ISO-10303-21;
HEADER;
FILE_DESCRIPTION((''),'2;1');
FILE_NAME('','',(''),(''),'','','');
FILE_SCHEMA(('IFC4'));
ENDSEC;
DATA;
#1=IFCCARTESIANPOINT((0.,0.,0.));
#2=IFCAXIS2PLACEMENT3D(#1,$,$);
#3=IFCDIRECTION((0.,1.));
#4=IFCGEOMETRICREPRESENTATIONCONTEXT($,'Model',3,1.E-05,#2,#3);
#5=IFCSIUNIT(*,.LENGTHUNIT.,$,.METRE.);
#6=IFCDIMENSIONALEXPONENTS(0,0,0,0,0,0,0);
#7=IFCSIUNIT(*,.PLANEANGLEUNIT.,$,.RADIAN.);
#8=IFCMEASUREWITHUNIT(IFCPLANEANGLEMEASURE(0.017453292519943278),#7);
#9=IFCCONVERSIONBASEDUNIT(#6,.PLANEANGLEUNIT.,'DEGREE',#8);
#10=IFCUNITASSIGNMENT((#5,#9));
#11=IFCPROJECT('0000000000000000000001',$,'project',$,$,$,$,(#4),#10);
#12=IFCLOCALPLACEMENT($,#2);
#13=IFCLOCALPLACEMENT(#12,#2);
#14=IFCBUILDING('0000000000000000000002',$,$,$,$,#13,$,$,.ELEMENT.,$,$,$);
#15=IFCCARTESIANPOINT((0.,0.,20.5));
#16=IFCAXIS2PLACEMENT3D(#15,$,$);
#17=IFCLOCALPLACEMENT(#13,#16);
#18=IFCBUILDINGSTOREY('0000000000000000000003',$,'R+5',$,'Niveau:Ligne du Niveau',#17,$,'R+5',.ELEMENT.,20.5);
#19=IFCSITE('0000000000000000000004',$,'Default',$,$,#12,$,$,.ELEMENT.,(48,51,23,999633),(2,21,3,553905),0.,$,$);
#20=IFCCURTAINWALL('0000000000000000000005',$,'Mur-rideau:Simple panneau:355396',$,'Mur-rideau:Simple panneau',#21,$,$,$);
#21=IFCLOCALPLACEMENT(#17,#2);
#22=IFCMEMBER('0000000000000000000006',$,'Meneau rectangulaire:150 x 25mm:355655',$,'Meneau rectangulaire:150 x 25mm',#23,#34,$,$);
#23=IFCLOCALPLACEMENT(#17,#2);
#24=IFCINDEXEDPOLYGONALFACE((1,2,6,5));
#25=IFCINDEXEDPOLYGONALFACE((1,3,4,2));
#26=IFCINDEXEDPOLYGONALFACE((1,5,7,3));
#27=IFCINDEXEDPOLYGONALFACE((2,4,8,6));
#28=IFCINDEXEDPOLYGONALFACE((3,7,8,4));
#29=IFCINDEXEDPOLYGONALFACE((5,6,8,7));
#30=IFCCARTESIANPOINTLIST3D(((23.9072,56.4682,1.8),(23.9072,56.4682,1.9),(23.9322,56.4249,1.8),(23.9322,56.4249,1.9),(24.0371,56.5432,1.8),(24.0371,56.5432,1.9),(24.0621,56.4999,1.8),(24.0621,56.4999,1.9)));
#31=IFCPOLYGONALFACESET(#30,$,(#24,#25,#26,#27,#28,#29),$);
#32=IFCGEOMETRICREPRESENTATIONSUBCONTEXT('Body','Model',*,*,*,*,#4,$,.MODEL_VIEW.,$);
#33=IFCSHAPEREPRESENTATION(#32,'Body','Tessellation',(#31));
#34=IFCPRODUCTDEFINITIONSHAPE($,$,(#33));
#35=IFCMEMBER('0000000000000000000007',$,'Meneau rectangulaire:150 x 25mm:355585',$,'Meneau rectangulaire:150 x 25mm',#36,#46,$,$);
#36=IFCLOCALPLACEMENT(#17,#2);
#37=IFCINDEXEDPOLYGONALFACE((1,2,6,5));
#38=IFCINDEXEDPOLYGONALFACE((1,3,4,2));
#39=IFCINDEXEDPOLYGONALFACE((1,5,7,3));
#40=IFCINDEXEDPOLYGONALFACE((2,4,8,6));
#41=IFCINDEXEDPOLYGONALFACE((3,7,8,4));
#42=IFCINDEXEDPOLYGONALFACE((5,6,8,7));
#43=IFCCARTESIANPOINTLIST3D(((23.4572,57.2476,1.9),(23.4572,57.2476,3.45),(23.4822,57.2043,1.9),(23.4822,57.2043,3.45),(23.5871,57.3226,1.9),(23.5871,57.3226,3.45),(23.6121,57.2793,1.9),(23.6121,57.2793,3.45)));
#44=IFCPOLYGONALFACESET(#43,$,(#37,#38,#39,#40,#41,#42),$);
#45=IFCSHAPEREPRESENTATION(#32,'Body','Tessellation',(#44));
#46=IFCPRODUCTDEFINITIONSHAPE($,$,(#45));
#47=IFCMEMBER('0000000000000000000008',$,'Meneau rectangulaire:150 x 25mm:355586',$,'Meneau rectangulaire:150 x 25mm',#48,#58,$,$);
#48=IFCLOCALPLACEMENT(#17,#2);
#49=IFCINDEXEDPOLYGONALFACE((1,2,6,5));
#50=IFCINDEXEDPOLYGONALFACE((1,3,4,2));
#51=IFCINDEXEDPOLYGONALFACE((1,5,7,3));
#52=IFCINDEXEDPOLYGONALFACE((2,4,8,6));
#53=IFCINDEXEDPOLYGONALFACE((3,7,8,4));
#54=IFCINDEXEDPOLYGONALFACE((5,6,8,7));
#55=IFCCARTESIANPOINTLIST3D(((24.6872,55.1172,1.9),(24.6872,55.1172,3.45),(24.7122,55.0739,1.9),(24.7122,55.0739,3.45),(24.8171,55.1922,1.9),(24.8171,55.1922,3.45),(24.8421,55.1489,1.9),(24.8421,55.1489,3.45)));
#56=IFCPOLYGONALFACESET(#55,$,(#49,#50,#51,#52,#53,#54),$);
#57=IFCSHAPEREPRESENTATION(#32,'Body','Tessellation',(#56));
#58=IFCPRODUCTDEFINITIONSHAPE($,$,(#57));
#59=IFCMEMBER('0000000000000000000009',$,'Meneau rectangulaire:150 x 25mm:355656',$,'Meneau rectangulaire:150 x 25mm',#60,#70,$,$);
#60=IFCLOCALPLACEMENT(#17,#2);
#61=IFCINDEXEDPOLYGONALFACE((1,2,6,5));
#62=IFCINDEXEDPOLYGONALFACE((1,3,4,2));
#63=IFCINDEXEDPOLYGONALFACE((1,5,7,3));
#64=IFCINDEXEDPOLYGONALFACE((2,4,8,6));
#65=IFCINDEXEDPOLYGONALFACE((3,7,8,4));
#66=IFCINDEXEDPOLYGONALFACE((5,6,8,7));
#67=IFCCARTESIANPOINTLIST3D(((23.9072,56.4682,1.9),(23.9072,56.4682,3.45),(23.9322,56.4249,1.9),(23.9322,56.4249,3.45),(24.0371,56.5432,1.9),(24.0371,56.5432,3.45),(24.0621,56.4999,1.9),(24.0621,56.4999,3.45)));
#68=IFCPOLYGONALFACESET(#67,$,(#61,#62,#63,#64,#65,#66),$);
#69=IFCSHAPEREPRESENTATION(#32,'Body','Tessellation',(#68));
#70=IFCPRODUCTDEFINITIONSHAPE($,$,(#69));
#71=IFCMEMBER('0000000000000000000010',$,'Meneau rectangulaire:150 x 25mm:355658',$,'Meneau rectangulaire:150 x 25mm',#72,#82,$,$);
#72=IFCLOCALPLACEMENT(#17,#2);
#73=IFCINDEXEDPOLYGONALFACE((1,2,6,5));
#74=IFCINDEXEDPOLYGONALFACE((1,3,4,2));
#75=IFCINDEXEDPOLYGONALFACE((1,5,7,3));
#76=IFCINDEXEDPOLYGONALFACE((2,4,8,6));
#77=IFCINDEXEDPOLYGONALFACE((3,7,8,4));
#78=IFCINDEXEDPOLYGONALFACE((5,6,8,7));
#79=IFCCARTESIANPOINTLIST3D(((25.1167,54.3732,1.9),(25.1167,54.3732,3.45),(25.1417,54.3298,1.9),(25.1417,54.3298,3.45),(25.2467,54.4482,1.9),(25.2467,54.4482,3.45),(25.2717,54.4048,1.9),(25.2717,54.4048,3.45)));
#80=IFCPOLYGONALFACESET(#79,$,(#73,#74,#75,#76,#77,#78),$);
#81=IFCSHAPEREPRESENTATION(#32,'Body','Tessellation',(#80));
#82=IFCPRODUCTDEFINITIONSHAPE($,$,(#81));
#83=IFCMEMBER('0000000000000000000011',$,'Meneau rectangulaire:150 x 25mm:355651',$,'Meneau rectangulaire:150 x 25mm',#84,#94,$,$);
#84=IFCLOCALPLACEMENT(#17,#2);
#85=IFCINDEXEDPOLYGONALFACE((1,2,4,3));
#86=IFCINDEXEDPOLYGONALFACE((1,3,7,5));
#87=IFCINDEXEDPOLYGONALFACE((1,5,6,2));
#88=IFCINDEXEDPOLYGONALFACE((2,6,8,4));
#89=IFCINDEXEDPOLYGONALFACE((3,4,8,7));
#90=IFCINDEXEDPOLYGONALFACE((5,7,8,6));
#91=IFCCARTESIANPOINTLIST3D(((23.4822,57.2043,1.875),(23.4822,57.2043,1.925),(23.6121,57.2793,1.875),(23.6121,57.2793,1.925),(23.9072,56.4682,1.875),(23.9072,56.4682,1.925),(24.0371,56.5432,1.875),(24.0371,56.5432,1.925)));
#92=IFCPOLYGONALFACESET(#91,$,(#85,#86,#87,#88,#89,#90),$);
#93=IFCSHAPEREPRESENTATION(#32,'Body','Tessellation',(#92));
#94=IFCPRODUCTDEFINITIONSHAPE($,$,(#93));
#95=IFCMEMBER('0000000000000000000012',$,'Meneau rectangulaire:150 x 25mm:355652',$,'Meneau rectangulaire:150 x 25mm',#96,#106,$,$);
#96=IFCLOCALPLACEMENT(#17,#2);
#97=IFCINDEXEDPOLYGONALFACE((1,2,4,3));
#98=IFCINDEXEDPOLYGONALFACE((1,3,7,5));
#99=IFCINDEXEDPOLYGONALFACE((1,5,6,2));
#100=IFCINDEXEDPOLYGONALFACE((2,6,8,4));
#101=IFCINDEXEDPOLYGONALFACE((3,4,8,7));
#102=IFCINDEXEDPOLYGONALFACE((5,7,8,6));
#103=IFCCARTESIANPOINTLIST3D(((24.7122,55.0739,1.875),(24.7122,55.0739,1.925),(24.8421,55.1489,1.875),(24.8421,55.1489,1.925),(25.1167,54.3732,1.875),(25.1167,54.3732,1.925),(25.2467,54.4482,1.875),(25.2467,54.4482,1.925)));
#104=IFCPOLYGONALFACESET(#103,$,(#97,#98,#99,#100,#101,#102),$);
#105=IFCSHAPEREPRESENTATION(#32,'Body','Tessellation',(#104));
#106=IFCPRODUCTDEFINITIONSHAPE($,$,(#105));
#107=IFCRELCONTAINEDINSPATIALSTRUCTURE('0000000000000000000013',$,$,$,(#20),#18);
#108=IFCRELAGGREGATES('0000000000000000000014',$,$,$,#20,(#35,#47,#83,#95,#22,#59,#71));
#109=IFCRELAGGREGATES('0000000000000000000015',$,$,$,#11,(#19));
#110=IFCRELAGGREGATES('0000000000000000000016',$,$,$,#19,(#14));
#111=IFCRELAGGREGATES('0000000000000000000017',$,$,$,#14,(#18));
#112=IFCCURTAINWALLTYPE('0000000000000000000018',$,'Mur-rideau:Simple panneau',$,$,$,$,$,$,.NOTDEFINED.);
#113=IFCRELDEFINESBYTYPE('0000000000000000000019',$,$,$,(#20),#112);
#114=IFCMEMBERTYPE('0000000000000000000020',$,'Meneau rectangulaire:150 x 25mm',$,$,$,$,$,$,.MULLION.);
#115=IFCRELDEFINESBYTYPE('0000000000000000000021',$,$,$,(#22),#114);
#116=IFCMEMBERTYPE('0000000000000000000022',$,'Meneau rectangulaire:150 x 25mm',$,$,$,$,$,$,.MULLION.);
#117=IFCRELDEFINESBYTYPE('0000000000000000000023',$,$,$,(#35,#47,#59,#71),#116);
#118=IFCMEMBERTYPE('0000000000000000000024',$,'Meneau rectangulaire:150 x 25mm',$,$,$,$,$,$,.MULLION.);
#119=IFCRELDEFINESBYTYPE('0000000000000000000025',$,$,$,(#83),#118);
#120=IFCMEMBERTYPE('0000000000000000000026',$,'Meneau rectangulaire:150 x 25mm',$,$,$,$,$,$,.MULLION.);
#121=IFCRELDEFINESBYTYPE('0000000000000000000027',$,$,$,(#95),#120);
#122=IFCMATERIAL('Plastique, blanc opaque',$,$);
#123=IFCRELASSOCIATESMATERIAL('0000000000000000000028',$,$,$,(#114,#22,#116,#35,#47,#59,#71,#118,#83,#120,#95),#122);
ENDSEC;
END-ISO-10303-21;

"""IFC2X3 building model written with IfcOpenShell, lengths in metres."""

from ifc_helpers import new_model, entity, si_unit, converted_unit, direction, frame, origin, origin_2d_with_axis, place, context, subcontext, project, spatial, rectangle, extrude, source, transform, mapped, material, type_object, type_shapes, element, aggregate, save


model = new_model("IFC2X3")

# Units and contexts
model_context = context("Model", 3, precision=1e-05, world=origin(), true_north=direction((0.0, 1.0)))
body_context = subcontext(model_context, "Body", "Model", "MODEL_VIEW")
ifc_project = project(units=[si_unit("LENGTHUNIT", "METRE"), converted_unit("PLANEANGLEUNIT", "DEGREE", entity("IfcPlaneAngleMeasure", 0.017453292519943278), si_unit("PLANEANGLEUNIT", "RADIAN"), dimensions=[0, 0, 0, 0, 0, 0, 0])], contexts=[model_context])

# Site, building, storey
site_placement = place(None, origin())
site = spatial("IfcSite", under=ifc_project, at=site_placement, Name="Default", CompositionType="ELEMENT", RefLatitude=(48, 51, 23, 999633), RefLongitude=(2, 21, 3, 553905), RefElevation=0.0)
building_placement = place(site_placement, origin())
building = spatial("IfcBuilding", under=site, at=building_placement, CompositionType="ELEMENT")
storey_placement = place(building_placement, frame((0.0, 0.0, 20.5)))
storey = spatial("IfcBuildingStorey", under=building, at=storey_placement, Name="R+5", ObjectType="Niveau:Ligne du Niveau", LongName="R+5", CompositionType="ELEMENT", Elevation=20.5)

# Curtain wall, members
curtain_wall_type = type_object("IfcCurtainWallType", Name="Mur-rideau:Simple panneau", PredefinedType="NOTDEFINED")
curtain_wall_placement = place(storey_placement, frame((0.0, 0.0, -20.5)))
curtain_wall = element("IfcCurtainWall", 1, at=curtain_wall_placement, inside=storey, type_object=curtain_wall_type, Name="Mur-rideau:Simple panneau:355396", ObjectType="Mur-rideau:Simple panneau")
ifc_material_1 = material(Name="Plastique, blanc opaque")
member_type_1 = type_object("IfcMemberType", Name="Meneau rectangulaire:150 x 25mm", PredefinedType="MULLION", material=ifc_material_1)
shared_shape_1 = source(origin(), body_context, "Body", "SweptSolid", [
    extrude(rectangle(XDim=0.05, YDim=0.15, at=origin_2d_with_axis()), frame((0.0, 0.0, -0.1), z_axis=(0.0, 0.0, 1.0), x_axis=(-1.0, 0.0, 0.0)), (0.0, 0.0, 1.0), 0.1),
])
type_shapes(member_type_1, [shared_shape_1])
member_1_placement = place(curtain_wall_placement, frame((23.9846, 56.484, 22.3), z_axis=(0.0, 0.0, -1.0), x_axis=(0.5, -0.866025, 0.0)))
member_1 = element("IfcMember", 2, at=member_1_placement, type_object=member_type_1, material=ifc_material_1, Name="Meneau rectangulaire:150 x 25mm:355655", ObjectType="Meneau rectangulaire:150 x 25mm", context=body_context, shape_type="MappedRepresentation", body=[
    mapped(shared_shape_1, transform((0.0, 0.0, 0.0), scale=1.0)),
])
member_type_2 = type_object("IfcMemberType", Name="Meneau rectangulaire:150 x 25mm", PredefinedType="MULLION", material=ifc_material_1)
shared_shape_2 = source(origin(), body_context, "Body", "SweptSolid", [
    extrude(rectangle(XDim=0.05, YDim=0.15, at=origin_2d_with_axis()), frame((0.0, 0.0, -1.55), z_axis=(0.0, 0.0, 1.0), x_axis=(-1.0, 0.0, 0.0)), (0.0, 0.0, 1.0), 1.55),
])
type_shapes(member_type_2, [shared_shape_2])
member_2_placement = place(curtain_wall_placement, frame((23.5346, 57.2634, 22.4), z_axis=(0.0, 0.0, -1.0), x_axis=(0.5, -0.866025, 0.0)))
member_2 = element("IfcMember", 3, at=member_2_placement, type_object=member_type_2, material=ifc_material_1, Name="Meneau rectangulaire:150 x 25mm:355585", ObjectType="Meneau rectangulaire:150 x 25mm", context=body_context, shape_type="MappedRepresentation", body=[
    mapped(shared_shape_2, transform((0.0, 0.0, 0.0), scale=1.0)),
])
member_3_placement = place(curtain_wall_placement, frame((24.7646, 55.133, 22.4), z_axis=(0.0, 0.0, -1.0), x_axis=(0.5, -0.866025, 0.0)))
member_3 = element("IfcMember", 4, at=member_3_placement, type_object=member_type_2, material=ifc_material_1, Name="Meneau rectangulaire:150 x 25mm:355586", ObjectType="Meneau rectangulaire:150 x 25mm", context=body_context, shape_type="MappedRepresentation", body=[
    mapped(shared_shape_2, transform((0.0, 0.0, 0.0), scale=1.0)),
])
member_4_placement = place(curtain_wall_placement, frame((23.9846, 56.484, 22.4), z_axis=(0.0, 0.0, -1.0), x_axis=(0.5, -0.866025, 0.0)))
member_4 = element("IfcMember", 5, at=member_4_placement, type_object=member_type_2, material=ifc_material_1, Name="Meneau rectangulaire:150 x 25mm:355656", ObjectType="Meneau rectangulaire:150 x 25mm", context=body_context, shape_type="MappedRepresentation", body=[
    mapped(shared_shape_2, transform((0.0, 0.0, 0.0), scale=1.0)),
])
member_5_placement = place(curtain_wall_placement, frame((25.1942, 54.389, 22.4), z_axis=(0.0, 0.0, -1.0), x_axis=(0.5, -0.866025, 0.0)))
member_5 = element("IfcMember", 6, at=member_5_placement, type_object=member_type_2, material=ifc_material_1, Name="Meneau rectangulaire:150 x 25mm:355658", ObjectType="Meneau rectangulaire:150 x 25mm", context=body_context, shape_type="MappedRepresentation", body=[
    mapped(shared_shape_2, transform((0.0, 0.0, 0.0), scale=1.0)),
])
member_type_3 = type_object("IfcMemberType", Name="Meneau rectangulaire:150 x 25mm", PredefinedType="MULLION", material=ifc_material_1)
shared_shape_3 = source(origin(), body_context, "Body", "SweptSolid", [
    extrude(rectangle(XDim=0.05, YDim=0.15, at=origin_2d_with_axis()), frame((0.0, 0.0, -0.85), z_axis=(0.0, 0.0, 1.0), x_axis=(-1.0, 0.0, 0.0)), (0.0, 0.0, 1.0), 0.85),
])
type_shapes(member_type_3, [shared_shape_3])
member_6_placement = place(curtain_wall_placement, frame((23.9721, 56.5057, 22.4), z_axis=(0.5, -0.866025, 0.0), x_axis=(0.0, 0.0, 1.0)))
member_6 = element("IfcMember", 7, at=member_6_placement, type_object=member_type_3, material=ifc_material_1, Name="Meneau rectangulaire:150 x 25mm:355651", ObjectType="Meneau rectangulaire:150 x 25mm", context=body_context, shape_type="MappedRepresentation", body=[
    mapped(shared_shape_3, transform((0.0, 0.0, 0.0), scale=1.0)),
])
member_type_4 = type_object("IfcMemberType", Name="Meneau rectangulaire:150 x 25mm", PredefinedType="MULLION", material=ifc_material_1)
shared_shape_4 = source(origin(), body_context, "Body", "SweptSolid", [
    extrude(rectangle(XDim=0.05, YDim=0.15, at=origin_2d_with_axis()), frame((0.0, 0.0, -0.8091), z_axis=(0.0, 0.0, 1.0), x_axis=(-1.0, 0.0, 0.0)), (0.0, 0.0, 1.0), 0.8091),
])
type_shapes(member_type_4, [shared_shape_4])
member_7_placement = place(curtain_wall_placement, frame((25.1817, 54.4107, 22.4), z_axis=(0.5, -0.866025, 0.0), x_axis=(0.0, 0.0, 1.0)))
member_7 = element("IfcMember", 8, at=member_7_placement, type_object=member_type_4, material=ifc_material_1, Name="Meneau rectangulaire:150 x 25mm:355652", ObjectType="Meneau rectangulaire:150 x 25mm", context=body_context, shape_type="MappedRepresentation", body=[
    mapped(shared_shape_4, transform((0.0, 0.0, 0.0), scale=1.0)),
])
aggregate(curtain_wall, [member_2, member_3, member_6, member_7, member_1, member_4, member_5])

save(model, "model.ifc")
